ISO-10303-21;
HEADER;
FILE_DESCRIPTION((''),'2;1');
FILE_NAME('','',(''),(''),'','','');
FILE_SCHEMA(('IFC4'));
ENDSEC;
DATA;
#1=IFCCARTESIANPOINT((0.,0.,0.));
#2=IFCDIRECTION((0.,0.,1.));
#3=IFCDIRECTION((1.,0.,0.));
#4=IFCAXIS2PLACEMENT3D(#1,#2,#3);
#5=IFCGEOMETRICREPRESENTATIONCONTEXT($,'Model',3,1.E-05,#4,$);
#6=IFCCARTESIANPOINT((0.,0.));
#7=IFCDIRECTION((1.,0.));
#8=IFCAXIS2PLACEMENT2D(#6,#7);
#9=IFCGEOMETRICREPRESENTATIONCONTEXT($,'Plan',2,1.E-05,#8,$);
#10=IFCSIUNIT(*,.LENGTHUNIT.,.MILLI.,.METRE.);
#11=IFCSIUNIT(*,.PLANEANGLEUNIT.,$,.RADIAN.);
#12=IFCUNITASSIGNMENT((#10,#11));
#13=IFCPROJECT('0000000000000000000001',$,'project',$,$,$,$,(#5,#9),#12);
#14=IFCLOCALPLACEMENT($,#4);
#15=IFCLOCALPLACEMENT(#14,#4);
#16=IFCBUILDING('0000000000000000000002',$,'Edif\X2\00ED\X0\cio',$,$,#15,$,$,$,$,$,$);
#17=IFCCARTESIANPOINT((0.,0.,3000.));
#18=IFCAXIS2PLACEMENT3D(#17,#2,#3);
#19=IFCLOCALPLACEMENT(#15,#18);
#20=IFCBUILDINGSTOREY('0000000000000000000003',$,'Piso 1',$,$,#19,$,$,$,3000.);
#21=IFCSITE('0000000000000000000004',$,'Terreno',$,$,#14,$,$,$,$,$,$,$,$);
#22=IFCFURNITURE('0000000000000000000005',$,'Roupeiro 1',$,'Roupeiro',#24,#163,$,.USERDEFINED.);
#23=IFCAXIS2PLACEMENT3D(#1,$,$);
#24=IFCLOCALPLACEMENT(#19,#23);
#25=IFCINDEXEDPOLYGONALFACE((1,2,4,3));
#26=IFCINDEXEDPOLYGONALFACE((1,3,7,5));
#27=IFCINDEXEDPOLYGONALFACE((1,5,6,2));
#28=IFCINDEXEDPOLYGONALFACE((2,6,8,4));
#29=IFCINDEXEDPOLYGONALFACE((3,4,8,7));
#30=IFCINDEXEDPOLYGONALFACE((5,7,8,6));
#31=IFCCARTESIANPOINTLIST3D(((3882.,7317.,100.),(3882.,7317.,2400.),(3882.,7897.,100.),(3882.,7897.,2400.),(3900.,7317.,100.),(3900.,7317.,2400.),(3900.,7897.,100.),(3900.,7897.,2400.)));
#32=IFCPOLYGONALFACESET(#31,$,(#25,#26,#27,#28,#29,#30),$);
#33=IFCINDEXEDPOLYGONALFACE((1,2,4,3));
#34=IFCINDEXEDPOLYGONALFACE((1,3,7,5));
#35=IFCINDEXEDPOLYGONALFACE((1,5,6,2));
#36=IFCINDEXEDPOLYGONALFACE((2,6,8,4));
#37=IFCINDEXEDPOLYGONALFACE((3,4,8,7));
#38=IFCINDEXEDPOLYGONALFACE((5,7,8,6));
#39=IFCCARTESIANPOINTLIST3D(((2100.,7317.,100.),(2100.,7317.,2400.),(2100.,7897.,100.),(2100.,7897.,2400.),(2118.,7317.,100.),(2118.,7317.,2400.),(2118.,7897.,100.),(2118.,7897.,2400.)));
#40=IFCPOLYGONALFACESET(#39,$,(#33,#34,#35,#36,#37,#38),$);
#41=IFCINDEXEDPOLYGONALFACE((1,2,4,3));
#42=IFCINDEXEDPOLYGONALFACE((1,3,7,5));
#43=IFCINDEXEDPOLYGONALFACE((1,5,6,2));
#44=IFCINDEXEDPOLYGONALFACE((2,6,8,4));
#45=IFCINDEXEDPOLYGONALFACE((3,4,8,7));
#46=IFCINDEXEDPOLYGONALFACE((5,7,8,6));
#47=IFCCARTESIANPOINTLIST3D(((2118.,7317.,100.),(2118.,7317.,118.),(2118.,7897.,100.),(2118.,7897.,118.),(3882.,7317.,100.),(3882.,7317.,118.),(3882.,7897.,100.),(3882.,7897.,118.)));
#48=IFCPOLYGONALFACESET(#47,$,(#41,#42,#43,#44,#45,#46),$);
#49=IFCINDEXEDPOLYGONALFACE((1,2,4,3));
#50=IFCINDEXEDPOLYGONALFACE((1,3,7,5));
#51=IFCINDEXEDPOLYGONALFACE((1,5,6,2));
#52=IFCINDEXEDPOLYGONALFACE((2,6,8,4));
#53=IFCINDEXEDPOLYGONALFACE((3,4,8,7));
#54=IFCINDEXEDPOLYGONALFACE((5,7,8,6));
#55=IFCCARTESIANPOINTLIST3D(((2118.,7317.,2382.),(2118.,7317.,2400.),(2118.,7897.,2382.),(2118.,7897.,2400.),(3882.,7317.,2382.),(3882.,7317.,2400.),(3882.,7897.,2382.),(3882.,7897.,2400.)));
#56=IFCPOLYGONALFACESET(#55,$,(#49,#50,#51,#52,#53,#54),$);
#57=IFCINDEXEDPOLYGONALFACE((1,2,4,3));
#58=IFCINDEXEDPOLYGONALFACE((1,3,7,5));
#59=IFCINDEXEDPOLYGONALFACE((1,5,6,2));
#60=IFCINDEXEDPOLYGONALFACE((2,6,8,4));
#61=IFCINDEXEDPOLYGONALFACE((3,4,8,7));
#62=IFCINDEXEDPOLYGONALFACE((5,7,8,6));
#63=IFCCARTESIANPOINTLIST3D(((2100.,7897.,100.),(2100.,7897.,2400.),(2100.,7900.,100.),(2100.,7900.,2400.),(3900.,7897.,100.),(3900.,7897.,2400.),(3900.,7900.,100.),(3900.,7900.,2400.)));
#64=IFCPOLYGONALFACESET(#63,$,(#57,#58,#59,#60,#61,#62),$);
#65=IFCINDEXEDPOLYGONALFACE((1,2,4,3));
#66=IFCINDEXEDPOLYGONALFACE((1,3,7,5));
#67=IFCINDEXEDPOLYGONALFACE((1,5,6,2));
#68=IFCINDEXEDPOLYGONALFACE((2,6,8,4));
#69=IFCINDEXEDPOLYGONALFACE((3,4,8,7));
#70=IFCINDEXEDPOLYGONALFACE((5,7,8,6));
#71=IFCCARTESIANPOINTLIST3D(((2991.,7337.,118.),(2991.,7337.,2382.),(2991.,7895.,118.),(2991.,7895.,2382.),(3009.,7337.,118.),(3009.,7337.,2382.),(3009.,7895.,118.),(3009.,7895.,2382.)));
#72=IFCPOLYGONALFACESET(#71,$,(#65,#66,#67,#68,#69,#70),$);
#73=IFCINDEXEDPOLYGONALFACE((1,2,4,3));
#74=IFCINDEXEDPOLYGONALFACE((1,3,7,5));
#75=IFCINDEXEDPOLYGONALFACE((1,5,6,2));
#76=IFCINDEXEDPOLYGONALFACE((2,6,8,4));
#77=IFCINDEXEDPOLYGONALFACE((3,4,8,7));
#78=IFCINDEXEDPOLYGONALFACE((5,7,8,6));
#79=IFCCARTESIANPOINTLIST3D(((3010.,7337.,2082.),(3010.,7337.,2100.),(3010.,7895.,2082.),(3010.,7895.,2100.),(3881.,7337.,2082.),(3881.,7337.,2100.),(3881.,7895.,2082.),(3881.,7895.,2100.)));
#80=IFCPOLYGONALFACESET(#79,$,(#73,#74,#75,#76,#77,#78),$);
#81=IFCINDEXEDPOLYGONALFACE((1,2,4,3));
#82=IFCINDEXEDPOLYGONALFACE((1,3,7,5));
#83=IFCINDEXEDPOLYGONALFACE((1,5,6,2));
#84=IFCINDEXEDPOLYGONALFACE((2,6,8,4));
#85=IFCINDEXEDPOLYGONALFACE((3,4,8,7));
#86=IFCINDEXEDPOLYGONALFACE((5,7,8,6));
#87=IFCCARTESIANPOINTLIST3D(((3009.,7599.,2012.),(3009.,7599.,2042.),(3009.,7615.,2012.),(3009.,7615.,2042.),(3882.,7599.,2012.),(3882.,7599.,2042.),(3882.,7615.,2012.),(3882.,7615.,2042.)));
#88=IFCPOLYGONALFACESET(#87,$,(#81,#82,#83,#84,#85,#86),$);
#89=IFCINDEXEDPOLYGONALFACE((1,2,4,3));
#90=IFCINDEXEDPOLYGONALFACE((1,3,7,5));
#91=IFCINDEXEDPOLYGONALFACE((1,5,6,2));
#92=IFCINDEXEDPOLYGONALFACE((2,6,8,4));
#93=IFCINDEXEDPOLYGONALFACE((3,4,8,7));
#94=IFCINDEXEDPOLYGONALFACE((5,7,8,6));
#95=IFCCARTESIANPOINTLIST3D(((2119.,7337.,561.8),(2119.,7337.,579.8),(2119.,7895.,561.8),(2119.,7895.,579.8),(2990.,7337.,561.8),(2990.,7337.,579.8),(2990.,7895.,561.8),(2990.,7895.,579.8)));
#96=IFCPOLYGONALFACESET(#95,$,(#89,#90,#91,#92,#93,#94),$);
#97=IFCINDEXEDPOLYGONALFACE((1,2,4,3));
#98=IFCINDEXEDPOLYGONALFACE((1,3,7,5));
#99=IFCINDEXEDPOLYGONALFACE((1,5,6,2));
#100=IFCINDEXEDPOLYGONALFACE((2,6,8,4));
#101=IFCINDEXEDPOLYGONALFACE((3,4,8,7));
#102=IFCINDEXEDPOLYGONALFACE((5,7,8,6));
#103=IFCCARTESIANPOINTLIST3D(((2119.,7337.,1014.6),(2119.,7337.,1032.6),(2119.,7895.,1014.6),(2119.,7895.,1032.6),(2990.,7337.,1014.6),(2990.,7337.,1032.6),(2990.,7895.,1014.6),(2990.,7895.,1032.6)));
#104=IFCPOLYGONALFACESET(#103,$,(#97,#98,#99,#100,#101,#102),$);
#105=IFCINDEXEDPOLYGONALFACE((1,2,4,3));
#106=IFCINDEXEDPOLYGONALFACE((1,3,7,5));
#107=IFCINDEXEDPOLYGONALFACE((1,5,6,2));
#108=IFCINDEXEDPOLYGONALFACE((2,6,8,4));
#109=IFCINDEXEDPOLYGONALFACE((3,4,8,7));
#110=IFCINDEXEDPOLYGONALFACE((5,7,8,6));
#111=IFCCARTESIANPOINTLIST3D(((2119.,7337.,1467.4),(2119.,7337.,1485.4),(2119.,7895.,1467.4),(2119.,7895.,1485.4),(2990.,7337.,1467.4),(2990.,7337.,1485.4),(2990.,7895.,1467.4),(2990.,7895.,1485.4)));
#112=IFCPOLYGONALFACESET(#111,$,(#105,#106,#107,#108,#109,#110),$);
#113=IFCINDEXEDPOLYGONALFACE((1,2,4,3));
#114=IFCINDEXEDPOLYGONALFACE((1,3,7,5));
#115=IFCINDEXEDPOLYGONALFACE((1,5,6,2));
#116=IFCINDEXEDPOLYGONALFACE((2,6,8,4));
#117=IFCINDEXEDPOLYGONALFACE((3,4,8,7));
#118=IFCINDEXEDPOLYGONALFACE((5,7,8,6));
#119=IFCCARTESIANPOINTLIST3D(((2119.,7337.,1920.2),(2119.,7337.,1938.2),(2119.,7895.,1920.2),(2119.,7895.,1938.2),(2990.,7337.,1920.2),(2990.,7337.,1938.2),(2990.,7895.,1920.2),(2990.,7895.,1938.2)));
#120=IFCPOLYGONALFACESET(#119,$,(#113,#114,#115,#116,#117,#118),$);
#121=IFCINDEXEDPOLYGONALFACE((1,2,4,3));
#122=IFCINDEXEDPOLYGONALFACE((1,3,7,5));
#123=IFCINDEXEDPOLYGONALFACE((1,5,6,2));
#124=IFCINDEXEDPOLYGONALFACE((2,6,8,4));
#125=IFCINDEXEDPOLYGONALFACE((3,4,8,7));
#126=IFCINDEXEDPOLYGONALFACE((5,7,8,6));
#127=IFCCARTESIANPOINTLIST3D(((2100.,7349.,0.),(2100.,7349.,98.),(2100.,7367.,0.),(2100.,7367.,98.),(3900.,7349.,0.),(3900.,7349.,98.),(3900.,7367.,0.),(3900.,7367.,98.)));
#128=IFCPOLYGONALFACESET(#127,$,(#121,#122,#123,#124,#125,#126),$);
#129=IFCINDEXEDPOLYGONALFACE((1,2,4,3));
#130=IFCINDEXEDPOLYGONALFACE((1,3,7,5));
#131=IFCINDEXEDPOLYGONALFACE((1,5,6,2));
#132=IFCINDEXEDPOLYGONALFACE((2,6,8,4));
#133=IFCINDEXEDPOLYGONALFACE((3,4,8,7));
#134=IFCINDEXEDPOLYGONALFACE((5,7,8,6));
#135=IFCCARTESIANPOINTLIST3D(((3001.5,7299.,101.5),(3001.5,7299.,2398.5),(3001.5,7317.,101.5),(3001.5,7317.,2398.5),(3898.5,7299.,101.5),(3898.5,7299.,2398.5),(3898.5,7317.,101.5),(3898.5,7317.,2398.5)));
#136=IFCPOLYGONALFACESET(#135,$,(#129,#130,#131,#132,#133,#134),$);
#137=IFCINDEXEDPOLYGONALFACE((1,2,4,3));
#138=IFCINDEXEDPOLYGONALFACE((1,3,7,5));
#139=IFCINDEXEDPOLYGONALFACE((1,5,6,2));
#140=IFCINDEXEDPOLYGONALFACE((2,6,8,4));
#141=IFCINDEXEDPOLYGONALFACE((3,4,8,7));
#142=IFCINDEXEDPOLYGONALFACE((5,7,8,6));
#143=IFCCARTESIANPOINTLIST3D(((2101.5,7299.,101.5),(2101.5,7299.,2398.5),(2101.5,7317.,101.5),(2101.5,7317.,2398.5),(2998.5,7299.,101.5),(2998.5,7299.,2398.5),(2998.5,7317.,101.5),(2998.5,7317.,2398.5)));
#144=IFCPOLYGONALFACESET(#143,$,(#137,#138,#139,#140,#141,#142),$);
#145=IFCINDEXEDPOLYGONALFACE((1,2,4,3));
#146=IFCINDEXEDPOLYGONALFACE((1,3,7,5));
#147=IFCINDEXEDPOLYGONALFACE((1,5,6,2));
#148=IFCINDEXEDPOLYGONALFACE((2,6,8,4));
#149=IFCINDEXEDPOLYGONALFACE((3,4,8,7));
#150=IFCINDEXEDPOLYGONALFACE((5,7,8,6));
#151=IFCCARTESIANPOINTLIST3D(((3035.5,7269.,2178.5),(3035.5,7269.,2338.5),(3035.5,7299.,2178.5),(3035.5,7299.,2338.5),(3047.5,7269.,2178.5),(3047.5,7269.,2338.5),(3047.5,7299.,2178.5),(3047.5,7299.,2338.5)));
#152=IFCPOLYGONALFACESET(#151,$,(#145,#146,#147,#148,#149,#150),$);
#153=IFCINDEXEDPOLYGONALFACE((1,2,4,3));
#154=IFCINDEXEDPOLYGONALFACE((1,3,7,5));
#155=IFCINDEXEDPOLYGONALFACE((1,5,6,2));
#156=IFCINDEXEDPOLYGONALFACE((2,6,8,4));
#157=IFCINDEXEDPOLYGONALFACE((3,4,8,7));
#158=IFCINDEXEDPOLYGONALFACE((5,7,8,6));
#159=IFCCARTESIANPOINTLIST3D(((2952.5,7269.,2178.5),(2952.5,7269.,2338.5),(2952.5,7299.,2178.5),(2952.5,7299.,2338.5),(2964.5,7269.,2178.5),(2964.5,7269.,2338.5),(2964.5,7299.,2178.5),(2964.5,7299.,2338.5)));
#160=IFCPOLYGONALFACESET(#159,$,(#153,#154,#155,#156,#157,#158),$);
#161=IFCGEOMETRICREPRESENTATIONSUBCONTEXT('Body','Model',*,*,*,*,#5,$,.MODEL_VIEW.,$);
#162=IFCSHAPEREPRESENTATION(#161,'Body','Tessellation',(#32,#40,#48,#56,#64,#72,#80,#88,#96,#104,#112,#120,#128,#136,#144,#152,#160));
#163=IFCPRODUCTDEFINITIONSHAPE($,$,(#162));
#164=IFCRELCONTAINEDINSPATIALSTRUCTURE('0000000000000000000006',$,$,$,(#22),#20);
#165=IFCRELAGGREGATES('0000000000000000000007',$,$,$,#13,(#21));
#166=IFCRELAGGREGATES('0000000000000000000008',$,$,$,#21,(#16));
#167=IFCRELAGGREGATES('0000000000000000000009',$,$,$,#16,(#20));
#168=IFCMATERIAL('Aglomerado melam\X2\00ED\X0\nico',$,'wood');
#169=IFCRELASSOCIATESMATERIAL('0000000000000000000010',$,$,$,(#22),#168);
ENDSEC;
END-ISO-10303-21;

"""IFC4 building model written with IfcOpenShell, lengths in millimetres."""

from ifc_helpers import new_model, si_unit, frame, frame_2d, origin, origin_with_axes, origin_2d_with_axis, place, context, subcontext, project, spatial, rectangle, extrude, material, element, save


model = new_model("IFC4")

# Units and contexts
model_context = context("Model", 3, precision=1e-05, world=origin_with_axes())
plan_context = context("Plan", 2, precision=1e-05, world=origin_2d_with_axis())
body_context = subcontext(model_context, "Body", "Model", "MODEL_VIEW")
ifc_project = project(units=[si_unit("LENGTHUNIT", "METRE", prefix="MILLI"), si_unit("PLANEANGLEUNIT", "RADIAN")], contexts=[model_context, plan_context])

# Site, building, storey
site_placement = place(None, origin_with_axes())
site = spatial("IfcSite", under=ifc_project, at=site_placement, Name="Terreno")
building_placement = place(site_placement, origin_with_axes())
building = spatial("IfcBuilding", under=site, at=building_placement, Name="Edifício")
storey_placement = place(building_placement, frame((0.0, 0.0, 3000.0), z_axis=(0.0, 0.0, 1.0), x_axis=(1.0, 0.0, 0.0)))
storey = spatial("IfcBuildingStorey", under=building, at=storey_placement, Name="Piso 1", Elevation=3000.0)

# Furniture
ifc_material_1 = material(Name="Aglomerado melamínico", Category="wood")
furniture_placement = place(storey_placement, frame((3900.0, 7900.0, 0.0), z_axis=(0.0, 0.0, 1.0), x_axis=(-1.0, 0.0, 0.0)))
element("IfcFurniture", 1, at=furniture_placement, inside=storey, material=ifc_material_1, Name="Roupeiro 1", ObjectType="Roupeiro", PredefinedType="USERDEFINED", context=body_context, shape_type="SweptSolid", body=[
    extrude(rectangle(XDim=18.0, YDim=580.0, at=frame_2d((9.0, 293.0))), frame((0.0, 0.0, 100.0)), (0.0, 0.0, 1.0), 2300.0),
    extrude(rectangle(XDim=18.0, YDim=580.0, at=frame_2d((1791.0, 293.0))), frame((0.0, 0.0, 100.0)), (0.0, 0.0, 1.0), 2300.0),
    extrude(rectangle(XDim=1764.0, YDim=580.0, at=frame_2d((900.0, 293.0))), frame((0.0, 0.0, 100.0)), (0.0, 0.0, 1.0), 18.0),
    extrude(rectangle(XDim=1764.0, YDim=580.0, at=frame_2d((900.0, 293.0))), frame((0.0, 0.0, 2382.0)), (0.0, 0.0, 1.0), 18.0),
    extrude(rectangle(XDim=1800.0, YDim=3.0, at=frame_2d((900.0, 1.5))), frame((0.0, 0.0, 100.0)), (0.0, 0.0, 1.0), 2300.0),
    extrude(rectangle(XDim=18.0, YDim=558.0, at=frame_2d((900.0, 284.0))), frame((0.0, 0.0, 118.0)), (0.0, 0.0, 1.0), 2264.0),
    extrude(rectangle(XDim=871.0, YDim=558.0, at=frame_2d((454.5, 284.0))), frame((0.0, 0.0, 2082.0)), (0.0, 0.0, 1.0), 18.0),
    extrude(rectangle(XDim=873.0, YDim=16.0, at=frame_2d((454.5, 293.0))), frame((0.0, 0.0, 2012.0)), (0.0, 0.0, 1.0), 30.0),
    extrude(rectangle(XDim=871.0, YDim=558.0, at=frame_2d((1345.5, 284.0))), frame((0.0, 0.0, 561.8)), (0.0, 0.0, 1.0), 18.0),
    extrude(rectangle(XDim=871.0, YDim=558.0, at=frame_2d((1345.5, 284.0))), frame((0.0, 0.0, 1014.6)), (0.0, 0.0, 1.0), 18.0),
    extrude(rectangle(XDim=871.0, YDim=558.0, at=frame_2d((1345.5, 284.0))), frame((0.0, 0.0, 1467.4)), (0.0, 0.0, 1.0), 18.0),
    extrude(rectangle(XDim=871.0, YDim=558.0, at=frame_2d((1345.5, 284.0))), frame((0.0, 0.0, 1920.2)), (0.0, 0.0, 1.0), 18.0),
    extrude(rectangle(XDim=1800.0, YDim=18.0, at=frame_2d((900.0, 542.0))), origin(), (0.0, 0.0, 1.0), 98.0),
    extrude(rectangle(XDim=897.0, YDim=18.0, at=frame_2d((450.0, 592.0))), frame((0.0, 0.0, 101.5)), (0.0, 0.0, 1.0), 2297.0),
    extrude(rectangle(XDim=897.0, YDim=18.0, at=frame_2d((1350.0, 592.0))), frame((0.0, 0.0, 101.5)), (0.0, 0.0, 1.0), 2297.0),
    extrude(rectangle(XDim=12.0, YDim=30.0, at=frame_2d((858.5, 616.0))), frame((0.0, 0.0, 2178.5)), (0.0, 0.0, 1.0), 160.0),
    extrude(rectangle(XDim=12.0, YDim=30.0, at=frame_2d((941.5, 616.0))), frame((0.0, 0.0, 2178.5)), (0.0, 0.0, 1.0), 160.0),
])

save(model, "model.ifc")
